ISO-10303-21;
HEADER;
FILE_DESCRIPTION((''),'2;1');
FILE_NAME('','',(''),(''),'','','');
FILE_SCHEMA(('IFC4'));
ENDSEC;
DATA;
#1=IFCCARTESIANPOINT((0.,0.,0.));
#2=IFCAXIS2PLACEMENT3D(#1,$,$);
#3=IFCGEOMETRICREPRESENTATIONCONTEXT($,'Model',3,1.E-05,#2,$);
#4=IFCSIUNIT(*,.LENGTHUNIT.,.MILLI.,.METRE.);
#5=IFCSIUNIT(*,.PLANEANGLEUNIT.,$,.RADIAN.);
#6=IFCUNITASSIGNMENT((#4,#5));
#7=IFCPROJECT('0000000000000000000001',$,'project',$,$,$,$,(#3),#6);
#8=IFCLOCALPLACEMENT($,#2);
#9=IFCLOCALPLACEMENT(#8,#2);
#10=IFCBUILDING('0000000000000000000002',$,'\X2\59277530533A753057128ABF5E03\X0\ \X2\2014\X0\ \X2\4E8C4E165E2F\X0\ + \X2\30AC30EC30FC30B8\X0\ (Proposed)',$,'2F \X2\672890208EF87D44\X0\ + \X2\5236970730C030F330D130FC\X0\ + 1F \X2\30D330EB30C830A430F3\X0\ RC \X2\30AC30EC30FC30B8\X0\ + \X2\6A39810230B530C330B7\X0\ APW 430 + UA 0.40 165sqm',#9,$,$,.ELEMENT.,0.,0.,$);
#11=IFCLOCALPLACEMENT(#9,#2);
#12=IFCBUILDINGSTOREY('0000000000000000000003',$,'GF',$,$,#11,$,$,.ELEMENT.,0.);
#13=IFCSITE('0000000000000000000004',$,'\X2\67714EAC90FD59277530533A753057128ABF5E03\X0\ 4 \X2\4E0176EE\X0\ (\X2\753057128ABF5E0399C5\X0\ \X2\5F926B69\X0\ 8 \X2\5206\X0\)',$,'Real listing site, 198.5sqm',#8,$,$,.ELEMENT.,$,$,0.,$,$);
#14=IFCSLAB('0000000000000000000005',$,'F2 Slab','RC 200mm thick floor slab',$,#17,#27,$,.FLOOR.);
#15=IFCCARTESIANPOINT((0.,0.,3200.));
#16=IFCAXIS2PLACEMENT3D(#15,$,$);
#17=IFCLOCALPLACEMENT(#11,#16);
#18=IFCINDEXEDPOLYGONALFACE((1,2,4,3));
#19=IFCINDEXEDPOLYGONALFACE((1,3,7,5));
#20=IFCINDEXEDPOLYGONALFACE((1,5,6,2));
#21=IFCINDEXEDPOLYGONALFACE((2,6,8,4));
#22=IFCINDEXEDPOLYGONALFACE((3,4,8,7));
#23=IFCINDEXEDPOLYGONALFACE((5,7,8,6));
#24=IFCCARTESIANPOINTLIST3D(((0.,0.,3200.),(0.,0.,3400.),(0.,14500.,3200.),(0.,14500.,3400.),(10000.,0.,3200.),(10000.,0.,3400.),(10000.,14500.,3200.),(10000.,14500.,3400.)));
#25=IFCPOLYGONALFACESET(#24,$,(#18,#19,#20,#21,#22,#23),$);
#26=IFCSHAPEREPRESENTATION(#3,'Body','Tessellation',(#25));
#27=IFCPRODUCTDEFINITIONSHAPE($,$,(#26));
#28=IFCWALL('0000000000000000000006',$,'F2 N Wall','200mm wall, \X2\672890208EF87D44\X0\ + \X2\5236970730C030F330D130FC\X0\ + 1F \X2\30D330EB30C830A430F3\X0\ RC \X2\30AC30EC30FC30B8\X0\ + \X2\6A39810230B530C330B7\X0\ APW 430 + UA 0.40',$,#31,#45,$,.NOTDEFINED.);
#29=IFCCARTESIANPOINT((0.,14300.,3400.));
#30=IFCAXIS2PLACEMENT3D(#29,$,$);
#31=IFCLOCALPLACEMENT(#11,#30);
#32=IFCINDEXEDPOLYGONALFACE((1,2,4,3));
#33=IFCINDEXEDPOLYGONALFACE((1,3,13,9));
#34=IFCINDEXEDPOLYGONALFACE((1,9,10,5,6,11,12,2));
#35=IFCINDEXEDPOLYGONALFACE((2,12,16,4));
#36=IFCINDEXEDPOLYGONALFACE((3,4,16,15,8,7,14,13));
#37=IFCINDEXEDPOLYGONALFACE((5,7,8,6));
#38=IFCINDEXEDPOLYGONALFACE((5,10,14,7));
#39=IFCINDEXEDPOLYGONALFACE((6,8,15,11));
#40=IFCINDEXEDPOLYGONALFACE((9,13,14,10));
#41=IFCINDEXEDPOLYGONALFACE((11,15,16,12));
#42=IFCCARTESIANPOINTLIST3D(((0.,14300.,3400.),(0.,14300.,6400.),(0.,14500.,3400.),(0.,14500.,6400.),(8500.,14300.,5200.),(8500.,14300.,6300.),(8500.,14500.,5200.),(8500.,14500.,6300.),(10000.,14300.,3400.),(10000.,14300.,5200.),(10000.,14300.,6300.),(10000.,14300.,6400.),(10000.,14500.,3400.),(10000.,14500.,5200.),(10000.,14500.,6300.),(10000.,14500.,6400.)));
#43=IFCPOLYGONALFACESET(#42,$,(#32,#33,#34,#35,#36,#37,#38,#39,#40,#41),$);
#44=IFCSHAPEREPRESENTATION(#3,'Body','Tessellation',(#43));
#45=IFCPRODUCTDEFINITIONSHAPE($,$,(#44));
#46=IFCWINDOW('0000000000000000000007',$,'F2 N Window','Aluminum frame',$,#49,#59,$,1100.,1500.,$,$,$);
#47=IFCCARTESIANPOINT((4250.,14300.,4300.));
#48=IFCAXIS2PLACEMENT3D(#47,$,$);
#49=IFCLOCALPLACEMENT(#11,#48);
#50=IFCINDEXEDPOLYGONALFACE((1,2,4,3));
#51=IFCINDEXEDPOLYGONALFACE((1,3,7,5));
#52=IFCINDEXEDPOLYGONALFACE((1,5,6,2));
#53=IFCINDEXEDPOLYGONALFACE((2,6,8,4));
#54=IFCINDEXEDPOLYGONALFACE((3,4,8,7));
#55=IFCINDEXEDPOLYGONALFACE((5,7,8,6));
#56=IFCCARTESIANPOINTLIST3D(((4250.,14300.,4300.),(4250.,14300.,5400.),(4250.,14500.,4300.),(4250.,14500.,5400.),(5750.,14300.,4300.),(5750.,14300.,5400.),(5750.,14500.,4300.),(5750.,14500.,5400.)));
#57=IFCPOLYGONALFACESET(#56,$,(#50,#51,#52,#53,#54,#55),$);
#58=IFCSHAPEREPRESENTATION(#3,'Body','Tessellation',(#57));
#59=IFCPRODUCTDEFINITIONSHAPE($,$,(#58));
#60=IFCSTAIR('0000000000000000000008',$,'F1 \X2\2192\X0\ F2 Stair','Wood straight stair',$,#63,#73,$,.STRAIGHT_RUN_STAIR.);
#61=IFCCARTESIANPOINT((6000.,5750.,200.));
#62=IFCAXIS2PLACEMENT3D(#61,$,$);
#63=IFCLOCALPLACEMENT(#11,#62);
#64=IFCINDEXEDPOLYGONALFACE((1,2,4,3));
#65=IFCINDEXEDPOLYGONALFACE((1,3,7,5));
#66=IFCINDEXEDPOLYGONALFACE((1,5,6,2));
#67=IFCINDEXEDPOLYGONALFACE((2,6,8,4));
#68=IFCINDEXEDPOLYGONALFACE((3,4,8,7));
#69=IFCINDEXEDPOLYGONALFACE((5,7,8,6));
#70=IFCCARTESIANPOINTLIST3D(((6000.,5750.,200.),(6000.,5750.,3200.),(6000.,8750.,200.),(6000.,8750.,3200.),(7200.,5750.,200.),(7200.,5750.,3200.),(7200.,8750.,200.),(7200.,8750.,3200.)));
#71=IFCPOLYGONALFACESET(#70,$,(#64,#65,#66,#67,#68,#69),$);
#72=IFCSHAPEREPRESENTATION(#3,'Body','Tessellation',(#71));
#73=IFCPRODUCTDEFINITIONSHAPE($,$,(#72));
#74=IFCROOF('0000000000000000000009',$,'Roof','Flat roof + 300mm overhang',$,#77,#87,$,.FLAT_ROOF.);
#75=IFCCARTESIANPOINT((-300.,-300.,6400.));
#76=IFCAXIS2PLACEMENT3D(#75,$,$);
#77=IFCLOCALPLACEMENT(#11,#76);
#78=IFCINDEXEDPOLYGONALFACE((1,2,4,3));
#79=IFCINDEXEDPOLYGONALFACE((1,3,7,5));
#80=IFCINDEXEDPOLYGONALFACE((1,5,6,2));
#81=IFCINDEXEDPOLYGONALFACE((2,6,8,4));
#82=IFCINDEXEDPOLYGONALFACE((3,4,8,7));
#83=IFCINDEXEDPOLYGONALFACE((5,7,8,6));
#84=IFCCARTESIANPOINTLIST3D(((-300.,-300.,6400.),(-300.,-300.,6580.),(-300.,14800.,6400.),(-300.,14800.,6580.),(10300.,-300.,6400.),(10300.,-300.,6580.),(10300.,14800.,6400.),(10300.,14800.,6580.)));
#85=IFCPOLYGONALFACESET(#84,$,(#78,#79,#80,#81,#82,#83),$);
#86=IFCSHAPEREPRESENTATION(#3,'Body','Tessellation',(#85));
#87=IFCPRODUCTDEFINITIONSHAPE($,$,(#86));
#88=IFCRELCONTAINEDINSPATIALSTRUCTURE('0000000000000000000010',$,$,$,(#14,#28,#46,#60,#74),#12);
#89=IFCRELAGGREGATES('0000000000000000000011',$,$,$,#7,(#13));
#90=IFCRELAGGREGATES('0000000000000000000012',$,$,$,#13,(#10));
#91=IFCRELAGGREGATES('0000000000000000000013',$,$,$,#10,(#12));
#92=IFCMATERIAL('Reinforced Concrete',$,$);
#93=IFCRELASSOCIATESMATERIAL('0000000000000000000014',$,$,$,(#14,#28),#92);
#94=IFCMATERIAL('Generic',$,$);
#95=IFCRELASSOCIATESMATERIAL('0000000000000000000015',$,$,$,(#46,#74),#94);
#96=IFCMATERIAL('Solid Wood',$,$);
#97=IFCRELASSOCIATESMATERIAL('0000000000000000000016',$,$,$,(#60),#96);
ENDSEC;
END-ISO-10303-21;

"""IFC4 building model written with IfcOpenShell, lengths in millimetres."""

from ifc_helpers import new_model, si_unit, frame, frame_2d, origin, place, context, project, spatial, rectangle, extrude, material, element, fill, save


model = new_model("IFC4")

# Units and contexts
model_context = context("Model", 3, precision=1e-05, world=origin())
ifc_project = project(units=[si_unit("LENGTHUNIT", "METRE", prefix="MILLI"), si_unit("PLANEANGLEUNIT", "RADIAN")], contexts=[model_context])

# Site, building, storey
site_placement = place(None, origin())
site = spatial("IfcSite", under=ifc_project, at=site_placement, Name="東京都大田区田園調布 4 丁目 (田園調布駅 徒歩 8 分)", ObjectType="Real listing site, 198.5sqm", CompositionType="ELEMENT", RefElevation=0.0)
building_placement = place(site_placement, origin())
building = spatial("IfcBuilding", under=site, at=building_placement, Name="大田区田園調布 — 二世帯 + ガレージ (Proposed)", ObjectType="2F 木造軸組 + 制震ダンパー + 1F ビルトイン RC ガレージ + 樹脂サッシ APW 430 + UA 0.40 165sqm", CompositionType="ELEMENT", ElevationOfRefHeight=0.0, ElevationOfTerrain=0.0)
storey_placement = place(building_placement, origin())
storey = spatial("IfcBuildingStorey", under=building, at=storey_placement, Name="GF", CompositionType="ELEMENT", Elevation=0.0)

# Slab
ifc_material_1 = material(Name="Reinforced Concrete")
slab_1_placement = place(storey_placement, frame((0.0, 0.0, 3200.0)))
element("IfcSlab", 1, at=slab_1_placement, inside=storey, material=ifc_material_1, Name="F2 Slab", Description="RC 200mm thick floor slab", PredefinedType="FLOOR", context=model_context, shape_type="SweptSolid", body=[
    extrude(rectangle(XDim=10000.0, YDim=14500.0, at=frame_2d((5000.0, 7250.0))), frame((0.0, 0.0, 3200.0)), (0.0, 0.0, 1.0), 200.0),
])

# Shared definitions
ifc_material_2 = material(Name="Generic")

# Shared definitions
ifc_material_3 = material(Name="Solid Wood")

# Wall, opening, window
wall_1_placement = place(storey_placement, frame((0.0, 14300.0, 3400.0)))
wall_1 = element("IfcWall", 2, at=wall_1_placement, inside=storey, material=ifc_material_1, Name="F2 N Wall", Description="200mm wall, 木造軸組 + 制震ダンパー + 1F ビルトイン RC ガレージ + 樹脂サッシ APW 430 + UA 0.40", PredefinedType="NOTDEFINED", context=model_context, shape_type="SweptSolid", body=[
    extrude(rectangle(XDim=10000.0, YDim=200.0, at=frame_2d((5000.0, 100.0))), frame((0.0, 14300.0, 3400.0)), (0.0, 0.0, 1.0), 3000.0),
])
opening_1_placement = place(storey_placement, frame((4250.0, 14300.0, 4300.0)))
opening_1 = element("IfcOpeningElement", 3, at=opening_1_placement, cuts=wall_1, PredefinedType="NOTDEFINED", context=model_context, shape_type="SweptSolid", body=[
    extrude(rectangle(XDim=1500.0, YDim=200.0, at=frame_2d((750.0, 100.0))), frame((4250.0, 14300.0, 4300.0)), (0.0, 0.0, 1.0), 1100.0),
])
window_1_placement = place(storey_placement, frame((4250.0, 14300.0, 4300.0)))
window_1 = element("IfcWindow", 4, at=window_1_placement, inside=storey, material=ifc_material_2, Name="F2 N Window", Description="Aluminum frame", OverallHeight=1100.0, OverallWidth=1500.0, context=model_context, shape_type="SweptSolid", body=[
    extrude(rectangle(XDim=1500.0, YDim=200.0, at=frame_2d((750.0, 100.0))), frame((4250.0, 14300.0, 4300.0)), (0.0, 0.0, 1.0), 1100.0),
])
fill(opening_1, window_1)

# Stair
stair_placement = place(storey_placement, frame((6000.0, 5750.0, 200.0)))
element("IfcStair", 5, at=stair_placement, inside=storey, material=ifc_material_3, Name="F1 → F2 Stair", Description="Wood straight stair", PredefinedType="STRAIGHT_RUN_STAIR", context=model_context, shape_type="SweptSolid", body=[
    extrude(rectangle(XDim=1200.0, YDim=3000.0, at=frame_2d((600.0, 1500.0))), frame((6000.0, 5750.0, 200.0)), (0.0, 0.0, 1.0), 3000.0),
])

# Roof
roof_placement = place(storey_placement, frame((-300.0, -300.0, 6400.0)))
element("IfcRoof", 6, at=roof_placement, inside=storey, material=ifc_material_2, Name="Roof", Description="Flat roof + 300mm overhang", PredefinedType="FLAT_ROOF", context=model_context, shape_type="SweptSolid", body=[
    extrude(rectangle(XDim=10600.0, YDim=15100.0, at=frame_2d((5300.0, 7550.0))), frame((-300.0, -300.0, 6400.0)), (0.0, 0.0, 1.0), 180.0),
])

save(model, "model.ifc")
